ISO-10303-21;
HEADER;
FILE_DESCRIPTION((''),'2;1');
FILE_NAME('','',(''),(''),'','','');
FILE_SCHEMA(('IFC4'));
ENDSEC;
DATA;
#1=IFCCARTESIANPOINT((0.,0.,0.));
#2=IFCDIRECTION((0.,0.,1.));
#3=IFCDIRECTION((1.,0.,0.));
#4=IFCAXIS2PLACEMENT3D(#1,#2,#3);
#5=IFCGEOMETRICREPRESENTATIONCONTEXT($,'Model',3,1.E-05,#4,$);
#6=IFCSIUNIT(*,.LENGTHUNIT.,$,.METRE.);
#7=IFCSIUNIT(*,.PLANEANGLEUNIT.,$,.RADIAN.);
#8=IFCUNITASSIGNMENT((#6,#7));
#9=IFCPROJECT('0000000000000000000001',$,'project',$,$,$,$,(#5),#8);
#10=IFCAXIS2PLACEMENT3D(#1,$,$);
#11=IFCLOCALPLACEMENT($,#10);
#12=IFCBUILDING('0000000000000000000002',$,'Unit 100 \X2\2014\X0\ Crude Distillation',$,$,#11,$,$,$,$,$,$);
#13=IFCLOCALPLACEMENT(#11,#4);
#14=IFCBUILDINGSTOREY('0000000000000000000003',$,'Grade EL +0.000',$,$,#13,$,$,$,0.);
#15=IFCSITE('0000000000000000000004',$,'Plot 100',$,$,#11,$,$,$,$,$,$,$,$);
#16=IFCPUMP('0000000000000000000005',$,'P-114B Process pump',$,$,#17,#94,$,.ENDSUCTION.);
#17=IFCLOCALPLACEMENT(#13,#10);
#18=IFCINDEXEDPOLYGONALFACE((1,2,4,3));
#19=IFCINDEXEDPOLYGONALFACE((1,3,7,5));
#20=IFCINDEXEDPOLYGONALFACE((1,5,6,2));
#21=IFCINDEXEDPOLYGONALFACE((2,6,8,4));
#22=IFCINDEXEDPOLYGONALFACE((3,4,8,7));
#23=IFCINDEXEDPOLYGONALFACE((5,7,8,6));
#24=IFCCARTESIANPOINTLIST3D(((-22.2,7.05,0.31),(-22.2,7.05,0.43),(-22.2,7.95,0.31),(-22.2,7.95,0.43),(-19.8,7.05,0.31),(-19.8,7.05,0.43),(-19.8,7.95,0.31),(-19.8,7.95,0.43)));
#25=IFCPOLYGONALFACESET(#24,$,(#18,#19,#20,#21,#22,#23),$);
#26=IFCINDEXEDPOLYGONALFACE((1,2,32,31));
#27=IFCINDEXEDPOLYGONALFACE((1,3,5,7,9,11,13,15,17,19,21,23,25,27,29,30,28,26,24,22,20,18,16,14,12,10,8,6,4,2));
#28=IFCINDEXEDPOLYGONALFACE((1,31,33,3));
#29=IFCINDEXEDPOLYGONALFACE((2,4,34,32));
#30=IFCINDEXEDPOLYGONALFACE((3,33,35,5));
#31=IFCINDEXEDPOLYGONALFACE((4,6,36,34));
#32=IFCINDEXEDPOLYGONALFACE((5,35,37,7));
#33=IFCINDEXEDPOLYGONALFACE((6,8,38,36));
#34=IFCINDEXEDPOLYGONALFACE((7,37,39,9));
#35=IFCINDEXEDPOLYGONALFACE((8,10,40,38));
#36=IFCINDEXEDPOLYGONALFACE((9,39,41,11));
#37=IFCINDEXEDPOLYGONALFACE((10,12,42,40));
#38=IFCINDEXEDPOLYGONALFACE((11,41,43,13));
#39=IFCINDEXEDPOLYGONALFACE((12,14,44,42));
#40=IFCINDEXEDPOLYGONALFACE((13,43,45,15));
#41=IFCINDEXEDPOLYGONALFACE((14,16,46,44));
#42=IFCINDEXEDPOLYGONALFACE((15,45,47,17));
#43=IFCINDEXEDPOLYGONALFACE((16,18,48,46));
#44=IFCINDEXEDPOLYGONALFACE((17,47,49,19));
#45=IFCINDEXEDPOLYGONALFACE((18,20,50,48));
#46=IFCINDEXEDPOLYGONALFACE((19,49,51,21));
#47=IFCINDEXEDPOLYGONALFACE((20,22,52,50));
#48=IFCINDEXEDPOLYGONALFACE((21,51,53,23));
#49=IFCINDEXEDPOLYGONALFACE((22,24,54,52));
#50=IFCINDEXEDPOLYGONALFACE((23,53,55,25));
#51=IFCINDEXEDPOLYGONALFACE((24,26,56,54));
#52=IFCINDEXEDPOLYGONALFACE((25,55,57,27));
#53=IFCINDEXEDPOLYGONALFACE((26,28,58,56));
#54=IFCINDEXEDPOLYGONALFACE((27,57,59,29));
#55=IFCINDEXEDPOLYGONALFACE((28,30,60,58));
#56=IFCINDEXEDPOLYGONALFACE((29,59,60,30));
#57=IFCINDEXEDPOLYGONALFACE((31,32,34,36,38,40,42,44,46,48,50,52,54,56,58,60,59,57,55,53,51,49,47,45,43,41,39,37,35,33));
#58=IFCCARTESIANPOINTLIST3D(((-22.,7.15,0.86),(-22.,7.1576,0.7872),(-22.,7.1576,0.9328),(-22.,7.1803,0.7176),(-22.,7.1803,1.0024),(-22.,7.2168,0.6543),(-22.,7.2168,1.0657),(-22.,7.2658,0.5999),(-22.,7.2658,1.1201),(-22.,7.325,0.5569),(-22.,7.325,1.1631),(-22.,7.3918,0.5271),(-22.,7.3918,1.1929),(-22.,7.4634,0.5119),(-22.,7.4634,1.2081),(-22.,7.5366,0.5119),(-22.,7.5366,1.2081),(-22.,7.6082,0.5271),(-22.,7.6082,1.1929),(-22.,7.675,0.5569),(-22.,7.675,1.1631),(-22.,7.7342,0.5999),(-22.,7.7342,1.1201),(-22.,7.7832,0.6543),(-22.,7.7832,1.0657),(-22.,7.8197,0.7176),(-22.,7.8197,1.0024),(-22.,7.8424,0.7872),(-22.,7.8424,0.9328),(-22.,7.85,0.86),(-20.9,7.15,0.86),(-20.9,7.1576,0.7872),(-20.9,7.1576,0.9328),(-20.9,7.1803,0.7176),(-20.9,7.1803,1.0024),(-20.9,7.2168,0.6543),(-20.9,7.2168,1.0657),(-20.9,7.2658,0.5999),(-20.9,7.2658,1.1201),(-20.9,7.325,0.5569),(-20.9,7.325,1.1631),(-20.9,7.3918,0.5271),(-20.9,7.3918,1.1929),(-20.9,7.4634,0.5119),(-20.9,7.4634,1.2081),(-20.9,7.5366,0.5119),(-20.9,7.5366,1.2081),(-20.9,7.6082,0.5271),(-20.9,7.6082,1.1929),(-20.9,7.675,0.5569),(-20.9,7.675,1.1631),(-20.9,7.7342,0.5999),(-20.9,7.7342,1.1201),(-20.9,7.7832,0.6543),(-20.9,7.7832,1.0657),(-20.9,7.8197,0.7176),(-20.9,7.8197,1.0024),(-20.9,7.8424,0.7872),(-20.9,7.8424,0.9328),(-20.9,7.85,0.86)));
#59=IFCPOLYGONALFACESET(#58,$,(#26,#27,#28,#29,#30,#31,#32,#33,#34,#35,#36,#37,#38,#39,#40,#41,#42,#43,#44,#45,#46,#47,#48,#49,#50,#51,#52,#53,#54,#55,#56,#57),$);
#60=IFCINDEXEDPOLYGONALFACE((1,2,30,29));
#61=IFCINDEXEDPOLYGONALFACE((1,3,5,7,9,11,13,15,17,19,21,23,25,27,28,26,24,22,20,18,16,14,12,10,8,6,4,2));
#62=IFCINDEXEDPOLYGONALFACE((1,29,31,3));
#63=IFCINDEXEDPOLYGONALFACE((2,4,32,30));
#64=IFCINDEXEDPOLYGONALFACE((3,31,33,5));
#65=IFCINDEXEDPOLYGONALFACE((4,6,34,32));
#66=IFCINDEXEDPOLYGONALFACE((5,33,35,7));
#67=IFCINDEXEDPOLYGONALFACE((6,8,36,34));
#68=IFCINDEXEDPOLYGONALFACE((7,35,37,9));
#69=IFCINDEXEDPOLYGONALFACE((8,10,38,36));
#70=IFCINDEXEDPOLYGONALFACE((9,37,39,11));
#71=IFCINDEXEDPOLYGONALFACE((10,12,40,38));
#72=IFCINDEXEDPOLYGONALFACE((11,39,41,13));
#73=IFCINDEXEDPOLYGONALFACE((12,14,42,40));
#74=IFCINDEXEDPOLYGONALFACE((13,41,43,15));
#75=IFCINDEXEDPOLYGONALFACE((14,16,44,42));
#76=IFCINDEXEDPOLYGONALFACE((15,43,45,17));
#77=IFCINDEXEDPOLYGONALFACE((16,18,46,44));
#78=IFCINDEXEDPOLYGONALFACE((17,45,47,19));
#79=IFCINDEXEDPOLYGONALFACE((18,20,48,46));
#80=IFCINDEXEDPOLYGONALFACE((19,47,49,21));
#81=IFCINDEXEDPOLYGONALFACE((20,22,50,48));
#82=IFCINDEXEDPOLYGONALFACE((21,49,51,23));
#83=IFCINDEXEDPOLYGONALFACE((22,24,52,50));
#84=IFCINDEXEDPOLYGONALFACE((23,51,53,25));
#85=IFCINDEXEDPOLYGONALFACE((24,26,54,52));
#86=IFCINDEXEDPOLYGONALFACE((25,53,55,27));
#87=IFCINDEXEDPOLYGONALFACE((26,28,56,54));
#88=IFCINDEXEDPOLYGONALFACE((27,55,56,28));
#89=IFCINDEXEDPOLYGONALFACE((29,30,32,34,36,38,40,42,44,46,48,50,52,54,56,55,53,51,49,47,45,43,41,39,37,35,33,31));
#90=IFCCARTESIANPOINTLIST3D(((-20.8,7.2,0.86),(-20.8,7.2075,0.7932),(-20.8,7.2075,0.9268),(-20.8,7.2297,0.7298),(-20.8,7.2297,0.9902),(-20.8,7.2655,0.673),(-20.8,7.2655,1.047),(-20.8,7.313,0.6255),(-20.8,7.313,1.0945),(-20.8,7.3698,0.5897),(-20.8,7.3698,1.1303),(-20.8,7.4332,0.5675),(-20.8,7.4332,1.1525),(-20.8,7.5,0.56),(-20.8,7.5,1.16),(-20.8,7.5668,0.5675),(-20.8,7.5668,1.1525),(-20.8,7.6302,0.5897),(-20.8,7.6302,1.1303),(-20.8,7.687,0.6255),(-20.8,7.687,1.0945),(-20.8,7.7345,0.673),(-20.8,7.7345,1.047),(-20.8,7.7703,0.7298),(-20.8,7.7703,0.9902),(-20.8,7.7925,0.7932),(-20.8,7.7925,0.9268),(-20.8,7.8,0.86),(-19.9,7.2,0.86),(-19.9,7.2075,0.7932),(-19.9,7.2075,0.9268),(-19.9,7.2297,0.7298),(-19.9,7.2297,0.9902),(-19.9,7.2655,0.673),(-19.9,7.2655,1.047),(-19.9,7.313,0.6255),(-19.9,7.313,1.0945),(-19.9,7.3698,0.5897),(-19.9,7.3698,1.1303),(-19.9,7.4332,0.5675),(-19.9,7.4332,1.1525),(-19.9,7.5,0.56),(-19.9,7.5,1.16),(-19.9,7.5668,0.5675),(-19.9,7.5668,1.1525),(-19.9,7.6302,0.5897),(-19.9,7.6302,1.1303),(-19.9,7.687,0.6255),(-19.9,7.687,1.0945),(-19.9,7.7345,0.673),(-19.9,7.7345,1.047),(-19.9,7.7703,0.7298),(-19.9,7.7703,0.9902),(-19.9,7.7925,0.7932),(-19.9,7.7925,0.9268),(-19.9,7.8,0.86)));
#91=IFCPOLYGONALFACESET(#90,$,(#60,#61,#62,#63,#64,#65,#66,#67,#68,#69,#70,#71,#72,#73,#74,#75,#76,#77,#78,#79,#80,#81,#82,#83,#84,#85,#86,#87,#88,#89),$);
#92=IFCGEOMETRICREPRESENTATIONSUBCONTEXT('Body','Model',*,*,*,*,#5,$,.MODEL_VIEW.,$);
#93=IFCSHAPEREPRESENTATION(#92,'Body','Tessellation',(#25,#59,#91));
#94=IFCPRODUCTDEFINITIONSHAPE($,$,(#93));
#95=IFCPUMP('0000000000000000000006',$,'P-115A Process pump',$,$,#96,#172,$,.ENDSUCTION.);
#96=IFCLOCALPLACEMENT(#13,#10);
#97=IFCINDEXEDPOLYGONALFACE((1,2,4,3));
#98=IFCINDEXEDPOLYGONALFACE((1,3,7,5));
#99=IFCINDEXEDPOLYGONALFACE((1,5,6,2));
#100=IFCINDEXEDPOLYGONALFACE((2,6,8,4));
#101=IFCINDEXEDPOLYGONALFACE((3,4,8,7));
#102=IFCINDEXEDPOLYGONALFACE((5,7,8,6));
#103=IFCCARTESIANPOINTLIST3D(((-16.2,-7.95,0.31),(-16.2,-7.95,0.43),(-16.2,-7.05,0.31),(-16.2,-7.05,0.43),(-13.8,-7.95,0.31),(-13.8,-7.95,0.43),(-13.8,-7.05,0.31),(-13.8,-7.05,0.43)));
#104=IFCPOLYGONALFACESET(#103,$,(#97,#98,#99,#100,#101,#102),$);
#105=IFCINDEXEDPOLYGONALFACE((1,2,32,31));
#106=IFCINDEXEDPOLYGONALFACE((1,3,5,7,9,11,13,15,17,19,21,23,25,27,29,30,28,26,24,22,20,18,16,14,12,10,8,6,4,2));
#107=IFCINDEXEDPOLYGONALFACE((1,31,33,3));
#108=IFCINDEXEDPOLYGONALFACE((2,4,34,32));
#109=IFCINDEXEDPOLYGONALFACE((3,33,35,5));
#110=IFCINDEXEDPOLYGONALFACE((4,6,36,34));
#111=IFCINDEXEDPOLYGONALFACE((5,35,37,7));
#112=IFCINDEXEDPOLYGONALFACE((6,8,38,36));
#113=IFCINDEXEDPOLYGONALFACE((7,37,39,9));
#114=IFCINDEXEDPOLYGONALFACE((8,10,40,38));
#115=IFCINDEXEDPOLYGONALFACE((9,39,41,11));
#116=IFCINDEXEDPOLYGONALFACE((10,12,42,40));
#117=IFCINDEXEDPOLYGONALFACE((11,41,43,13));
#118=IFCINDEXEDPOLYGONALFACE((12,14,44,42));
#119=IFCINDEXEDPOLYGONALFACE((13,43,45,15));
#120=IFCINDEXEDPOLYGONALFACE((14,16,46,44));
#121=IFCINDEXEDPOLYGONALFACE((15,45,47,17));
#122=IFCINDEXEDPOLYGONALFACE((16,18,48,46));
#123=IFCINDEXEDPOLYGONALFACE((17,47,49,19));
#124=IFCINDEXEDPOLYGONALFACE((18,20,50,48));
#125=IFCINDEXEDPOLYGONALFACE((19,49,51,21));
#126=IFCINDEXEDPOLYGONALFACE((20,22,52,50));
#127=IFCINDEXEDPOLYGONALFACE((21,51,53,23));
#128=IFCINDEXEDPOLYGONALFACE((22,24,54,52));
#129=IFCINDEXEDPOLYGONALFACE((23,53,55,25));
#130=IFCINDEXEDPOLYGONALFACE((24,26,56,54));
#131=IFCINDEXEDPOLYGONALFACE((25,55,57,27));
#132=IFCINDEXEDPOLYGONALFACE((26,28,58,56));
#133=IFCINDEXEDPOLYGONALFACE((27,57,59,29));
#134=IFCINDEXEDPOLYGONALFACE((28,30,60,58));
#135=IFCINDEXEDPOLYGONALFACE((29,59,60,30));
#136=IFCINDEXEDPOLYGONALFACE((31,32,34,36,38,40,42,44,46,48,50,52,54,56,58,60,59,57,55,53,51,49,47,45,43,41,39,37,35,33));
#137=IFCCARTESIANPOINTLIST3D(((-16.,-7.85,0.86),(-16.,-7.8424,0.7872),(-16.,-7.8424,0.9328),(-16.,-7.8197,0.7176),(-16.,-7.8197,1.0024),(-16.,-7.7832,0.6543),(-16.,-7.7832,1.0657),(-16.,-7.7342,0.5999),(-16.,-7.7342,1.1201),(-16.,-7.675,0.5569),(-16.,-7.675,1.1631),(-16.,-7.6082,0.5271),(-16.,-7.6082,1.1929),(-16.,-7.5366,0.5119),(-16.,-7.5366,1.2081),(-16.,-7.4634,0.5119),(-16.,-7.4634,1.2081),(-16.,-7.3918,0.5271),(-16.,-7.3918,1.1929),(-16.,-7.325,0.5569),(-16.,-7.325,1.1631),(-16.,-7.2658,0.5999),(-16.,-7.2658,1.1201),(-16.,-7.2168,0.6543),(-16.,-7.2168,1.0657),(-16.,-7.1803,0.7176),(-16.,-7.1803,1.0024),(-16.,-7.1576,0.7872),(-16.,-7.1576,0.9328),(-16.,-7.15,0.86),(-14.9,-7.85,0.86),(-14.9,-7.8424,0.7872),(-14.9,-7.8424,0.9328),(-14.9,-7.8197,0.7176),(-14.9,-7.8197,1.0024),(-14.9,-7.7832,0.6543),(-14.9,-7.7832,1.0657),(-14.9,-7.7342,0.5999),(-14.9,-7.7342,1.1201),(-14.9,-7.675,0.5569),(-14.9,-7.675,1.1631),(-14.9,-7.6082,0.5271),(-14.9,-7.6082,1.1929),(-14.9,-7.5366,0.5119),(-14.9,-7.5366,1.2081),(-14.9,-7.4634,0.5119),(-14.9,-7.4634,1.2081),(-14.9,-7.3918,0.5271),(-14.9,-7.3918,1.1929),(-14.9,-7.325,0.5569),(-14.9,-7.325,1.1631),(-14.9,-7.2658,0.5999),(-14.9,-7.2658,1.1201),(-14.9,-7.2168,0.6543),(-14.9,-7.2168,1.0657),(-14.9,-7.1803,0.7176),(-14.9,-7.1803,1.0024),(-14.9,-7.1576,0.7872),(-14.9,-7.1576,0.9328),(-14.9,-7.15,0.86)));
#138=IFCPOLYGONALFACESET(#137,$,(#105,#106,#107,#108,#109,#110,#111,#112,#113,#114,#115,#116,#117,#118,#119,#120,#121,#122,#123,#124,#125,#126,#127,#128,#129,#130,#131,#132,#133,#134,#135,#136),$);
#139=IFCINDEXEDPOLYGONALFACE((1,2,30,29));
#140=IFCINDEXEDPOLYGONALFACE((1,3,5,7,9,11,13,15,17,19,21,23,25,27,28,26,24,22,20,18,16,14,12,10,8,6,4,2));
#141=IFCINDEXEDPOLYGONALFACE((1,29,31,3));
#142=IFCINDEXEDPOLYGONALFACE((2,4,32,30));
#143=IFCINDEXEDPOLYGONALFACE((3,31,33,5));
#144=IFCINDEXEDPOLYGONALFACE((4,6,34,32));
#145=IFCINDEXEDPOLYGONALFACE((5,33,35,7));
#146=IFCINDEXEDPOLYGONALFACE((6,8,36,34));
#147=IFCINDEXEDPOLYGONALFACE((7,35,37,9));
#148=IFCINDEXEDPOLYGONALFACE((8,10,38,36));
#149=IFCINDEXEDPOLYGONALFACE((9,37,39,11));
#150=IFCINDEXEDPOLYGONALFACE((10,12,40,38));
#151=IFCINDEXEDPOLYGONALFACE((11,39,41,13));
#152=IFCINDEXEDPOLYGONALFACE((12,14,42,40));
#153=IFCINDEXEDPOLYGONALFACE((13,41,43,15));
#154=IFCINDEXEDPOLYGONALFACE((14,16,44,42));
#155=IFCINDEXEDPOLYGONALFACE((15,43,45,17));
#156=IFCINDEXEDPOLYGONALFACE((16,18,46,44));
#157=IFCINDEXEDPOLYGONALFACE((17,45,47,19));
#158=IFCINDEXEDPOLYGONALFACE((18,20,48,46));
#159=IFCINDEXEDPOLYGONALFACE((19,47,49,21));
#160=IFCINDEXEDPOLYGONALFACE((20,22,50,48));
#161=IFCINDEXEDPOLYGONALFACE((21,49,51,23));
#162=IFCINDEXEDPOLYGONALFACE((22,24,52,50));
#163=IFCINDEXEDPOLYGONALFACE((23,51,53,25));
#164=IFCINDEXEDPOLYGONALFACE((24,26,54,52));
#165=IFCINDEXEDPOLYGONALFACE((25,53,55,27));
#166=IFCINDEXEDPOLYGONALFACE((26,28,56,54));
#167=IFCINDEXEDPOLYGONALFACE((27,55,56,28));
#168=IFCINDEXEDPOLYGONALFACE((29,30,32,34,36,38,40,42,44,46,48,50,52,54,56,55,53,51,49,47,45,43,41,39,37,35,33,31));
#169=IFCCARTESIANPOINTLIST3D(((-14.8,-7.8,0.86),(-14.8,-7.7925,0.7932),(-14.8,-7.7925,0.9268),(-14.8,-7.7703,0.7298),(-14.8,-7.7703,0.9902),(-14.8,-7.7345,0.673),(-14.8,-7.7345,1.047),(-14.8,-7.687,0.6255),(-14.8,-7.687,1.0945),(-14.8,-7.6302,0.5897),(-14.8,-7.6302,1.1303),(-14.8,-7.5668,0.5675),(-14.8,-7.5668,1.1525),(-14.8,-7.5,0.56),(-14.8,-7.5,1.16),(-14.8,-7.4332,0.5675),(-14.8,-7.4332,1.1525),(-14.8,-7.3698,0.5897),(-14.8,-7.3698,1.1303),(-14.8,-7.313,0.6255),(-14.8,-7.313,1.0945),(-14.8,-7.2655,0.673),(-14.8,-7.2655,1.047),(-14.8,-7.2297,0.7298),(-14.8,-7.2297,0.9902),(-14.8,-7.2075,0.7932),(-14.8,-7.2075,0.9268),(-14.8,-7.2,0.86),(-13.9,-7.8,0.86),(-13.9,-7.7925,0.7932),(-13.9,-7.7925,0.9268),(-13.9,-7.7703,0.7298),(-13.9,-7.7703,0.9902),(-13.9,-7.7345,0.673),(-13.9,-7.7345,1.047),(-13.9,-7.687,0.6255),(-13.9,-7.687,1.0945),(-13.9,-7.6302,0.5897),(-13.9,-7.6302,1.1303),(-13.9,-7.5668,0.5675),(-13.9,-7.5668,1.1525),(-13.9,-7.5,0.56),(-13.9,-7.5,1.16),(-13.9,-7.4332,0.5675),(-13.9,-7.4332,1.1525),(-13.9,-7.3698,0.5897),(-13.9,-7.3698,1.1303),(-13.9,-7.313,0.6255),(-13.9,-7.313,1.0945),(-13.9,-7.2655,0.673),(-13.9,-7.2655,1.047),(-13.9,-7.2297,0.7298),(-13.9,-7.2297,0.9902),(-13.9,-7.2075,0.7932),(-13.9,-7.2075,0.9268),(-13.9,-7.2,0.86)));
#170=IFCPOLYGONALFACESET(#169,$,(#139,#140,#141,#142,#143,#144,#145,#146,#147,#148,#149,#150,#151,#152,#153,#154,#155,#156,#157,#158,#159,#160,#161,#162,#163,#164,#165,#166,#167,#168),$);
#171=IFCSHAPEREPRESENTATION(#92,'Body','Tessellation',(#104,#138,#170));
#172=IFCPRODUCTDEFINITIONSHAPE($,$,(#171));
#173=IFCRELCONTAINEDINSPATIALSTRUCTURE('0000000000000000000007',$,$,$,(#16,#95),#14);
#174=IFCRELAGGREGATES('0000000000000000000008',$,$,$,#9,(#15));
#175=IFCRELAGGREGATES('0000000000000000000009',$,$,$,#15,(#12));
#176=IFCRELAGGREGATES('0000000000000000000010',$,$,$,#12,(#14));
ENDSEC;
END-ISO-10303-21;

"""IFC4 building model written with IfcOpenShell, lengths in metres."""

from ifc_helpers import new_model, si_unit, frame, origin, origin_with_axes, origin_2d, place, context, subcontext, project, spatial, rectangle, circle, extrude, element, save


model = new_model("IFC4")

# Units and contexts
model_context = context("Model", 3, precision=1e-05, world=origin_with_axes())
body_context = subcontext(model_context, "Body", "Model", "MODEL_VIEW")
ifc_project = project(units=[si_unit("LENGTHUNIT", "METRE"), si_unit("PLANEANGLEUNIT", "RADIAN")], contexts=[model_context])

# Site, building, storey
placement = place(None, origin())
site = spatial("IfcSite", under=ifc_project, at=placement, Name="Plot 100")
building = spatial("IfcBuilding", under=site, at=placement, Name="Unit 100 — Crude Distillation")
storey_placement = place(placement, origin_with_axes())
storey = spatial("IfcBuildingStorey", under=building, at=storey_placement, Name="Grade EL +0.000", Elevation=0.0)

# Pumps
pump_1_placement = place(storey_placement, origin_with_axes())
element("IfcPump", 1, at=pump_1_placement, inside=storey, Name="P-114B Process pump", PredefinedType="ENDSUCTION", context=body_context, shape_type="SweptSolid", body=[
    extrude(rectangle(XDim=2.4, YDim=0.9, at=origin_2d()), frame((-21.0, 7.5, 0.31), z_axis=(0.0, 0.0, 1.0), x_axis=(1.0, 0.0, 0.0)), (0.0, 0.0, 1.0), 0.12),
    extrude(circle(Radius=0.35, at=origin_2d()), frame((-22.0, 7.5, 0.86), z_axis=(1.0, 0.0, 0.0), x_axis=(0.0, 1.0, 0.0)), (0.0, 0.0, 1.0), 1.1),
    extrude(circle(Radius=0.3, at=origin_2d()), frame((-20.8, 7.5, 0.86), z_axis=(1.0, 0.0, 0.0), x_axis=(0.0, 1.0, 0.0)), (0.0, 0.0, 1.0), 0.9),
])
pump_2_placement = place(storey_placement, origin_with_axes())
element("IfcPump", 2, at=pump_2_placement, inside=storey, Name="P-115A Process pump", PredefinedType="ENDSUCTION", context=body_context, shape_type="SweptSolid", body=[
    extrude(rectangle(XDim=2.4, YDim=0.9, at=origin_2d()), frame((-15.0, -7.5, 0.31), z_axis=(0.0, 0.0, 1.0), x_axis=(1.0, 0.0, 0.0)), (0.0, 0.0, 1.0), 0.12),
    extrude(circle(Radius=0.35, at=origin_2d()), frame((-16.0, -7.5, 0.86), z_axis=(1.0, 0.0, 0.0), x_axis=(0.0, 1.0, 0.0)), (0.0, 0.0, 1.0), 1.1),
    extrude(circle(Radius=0.3, at=origin_2d()), frame((-14.8, -7.5, 0.86), z_axis=(1.0, 0.0, 0.0), x_axis=(0.0, 1.0, 0.0)), (0.0, 0.0, 1.0), 0.9),
])

save(model, "model.ifc")
